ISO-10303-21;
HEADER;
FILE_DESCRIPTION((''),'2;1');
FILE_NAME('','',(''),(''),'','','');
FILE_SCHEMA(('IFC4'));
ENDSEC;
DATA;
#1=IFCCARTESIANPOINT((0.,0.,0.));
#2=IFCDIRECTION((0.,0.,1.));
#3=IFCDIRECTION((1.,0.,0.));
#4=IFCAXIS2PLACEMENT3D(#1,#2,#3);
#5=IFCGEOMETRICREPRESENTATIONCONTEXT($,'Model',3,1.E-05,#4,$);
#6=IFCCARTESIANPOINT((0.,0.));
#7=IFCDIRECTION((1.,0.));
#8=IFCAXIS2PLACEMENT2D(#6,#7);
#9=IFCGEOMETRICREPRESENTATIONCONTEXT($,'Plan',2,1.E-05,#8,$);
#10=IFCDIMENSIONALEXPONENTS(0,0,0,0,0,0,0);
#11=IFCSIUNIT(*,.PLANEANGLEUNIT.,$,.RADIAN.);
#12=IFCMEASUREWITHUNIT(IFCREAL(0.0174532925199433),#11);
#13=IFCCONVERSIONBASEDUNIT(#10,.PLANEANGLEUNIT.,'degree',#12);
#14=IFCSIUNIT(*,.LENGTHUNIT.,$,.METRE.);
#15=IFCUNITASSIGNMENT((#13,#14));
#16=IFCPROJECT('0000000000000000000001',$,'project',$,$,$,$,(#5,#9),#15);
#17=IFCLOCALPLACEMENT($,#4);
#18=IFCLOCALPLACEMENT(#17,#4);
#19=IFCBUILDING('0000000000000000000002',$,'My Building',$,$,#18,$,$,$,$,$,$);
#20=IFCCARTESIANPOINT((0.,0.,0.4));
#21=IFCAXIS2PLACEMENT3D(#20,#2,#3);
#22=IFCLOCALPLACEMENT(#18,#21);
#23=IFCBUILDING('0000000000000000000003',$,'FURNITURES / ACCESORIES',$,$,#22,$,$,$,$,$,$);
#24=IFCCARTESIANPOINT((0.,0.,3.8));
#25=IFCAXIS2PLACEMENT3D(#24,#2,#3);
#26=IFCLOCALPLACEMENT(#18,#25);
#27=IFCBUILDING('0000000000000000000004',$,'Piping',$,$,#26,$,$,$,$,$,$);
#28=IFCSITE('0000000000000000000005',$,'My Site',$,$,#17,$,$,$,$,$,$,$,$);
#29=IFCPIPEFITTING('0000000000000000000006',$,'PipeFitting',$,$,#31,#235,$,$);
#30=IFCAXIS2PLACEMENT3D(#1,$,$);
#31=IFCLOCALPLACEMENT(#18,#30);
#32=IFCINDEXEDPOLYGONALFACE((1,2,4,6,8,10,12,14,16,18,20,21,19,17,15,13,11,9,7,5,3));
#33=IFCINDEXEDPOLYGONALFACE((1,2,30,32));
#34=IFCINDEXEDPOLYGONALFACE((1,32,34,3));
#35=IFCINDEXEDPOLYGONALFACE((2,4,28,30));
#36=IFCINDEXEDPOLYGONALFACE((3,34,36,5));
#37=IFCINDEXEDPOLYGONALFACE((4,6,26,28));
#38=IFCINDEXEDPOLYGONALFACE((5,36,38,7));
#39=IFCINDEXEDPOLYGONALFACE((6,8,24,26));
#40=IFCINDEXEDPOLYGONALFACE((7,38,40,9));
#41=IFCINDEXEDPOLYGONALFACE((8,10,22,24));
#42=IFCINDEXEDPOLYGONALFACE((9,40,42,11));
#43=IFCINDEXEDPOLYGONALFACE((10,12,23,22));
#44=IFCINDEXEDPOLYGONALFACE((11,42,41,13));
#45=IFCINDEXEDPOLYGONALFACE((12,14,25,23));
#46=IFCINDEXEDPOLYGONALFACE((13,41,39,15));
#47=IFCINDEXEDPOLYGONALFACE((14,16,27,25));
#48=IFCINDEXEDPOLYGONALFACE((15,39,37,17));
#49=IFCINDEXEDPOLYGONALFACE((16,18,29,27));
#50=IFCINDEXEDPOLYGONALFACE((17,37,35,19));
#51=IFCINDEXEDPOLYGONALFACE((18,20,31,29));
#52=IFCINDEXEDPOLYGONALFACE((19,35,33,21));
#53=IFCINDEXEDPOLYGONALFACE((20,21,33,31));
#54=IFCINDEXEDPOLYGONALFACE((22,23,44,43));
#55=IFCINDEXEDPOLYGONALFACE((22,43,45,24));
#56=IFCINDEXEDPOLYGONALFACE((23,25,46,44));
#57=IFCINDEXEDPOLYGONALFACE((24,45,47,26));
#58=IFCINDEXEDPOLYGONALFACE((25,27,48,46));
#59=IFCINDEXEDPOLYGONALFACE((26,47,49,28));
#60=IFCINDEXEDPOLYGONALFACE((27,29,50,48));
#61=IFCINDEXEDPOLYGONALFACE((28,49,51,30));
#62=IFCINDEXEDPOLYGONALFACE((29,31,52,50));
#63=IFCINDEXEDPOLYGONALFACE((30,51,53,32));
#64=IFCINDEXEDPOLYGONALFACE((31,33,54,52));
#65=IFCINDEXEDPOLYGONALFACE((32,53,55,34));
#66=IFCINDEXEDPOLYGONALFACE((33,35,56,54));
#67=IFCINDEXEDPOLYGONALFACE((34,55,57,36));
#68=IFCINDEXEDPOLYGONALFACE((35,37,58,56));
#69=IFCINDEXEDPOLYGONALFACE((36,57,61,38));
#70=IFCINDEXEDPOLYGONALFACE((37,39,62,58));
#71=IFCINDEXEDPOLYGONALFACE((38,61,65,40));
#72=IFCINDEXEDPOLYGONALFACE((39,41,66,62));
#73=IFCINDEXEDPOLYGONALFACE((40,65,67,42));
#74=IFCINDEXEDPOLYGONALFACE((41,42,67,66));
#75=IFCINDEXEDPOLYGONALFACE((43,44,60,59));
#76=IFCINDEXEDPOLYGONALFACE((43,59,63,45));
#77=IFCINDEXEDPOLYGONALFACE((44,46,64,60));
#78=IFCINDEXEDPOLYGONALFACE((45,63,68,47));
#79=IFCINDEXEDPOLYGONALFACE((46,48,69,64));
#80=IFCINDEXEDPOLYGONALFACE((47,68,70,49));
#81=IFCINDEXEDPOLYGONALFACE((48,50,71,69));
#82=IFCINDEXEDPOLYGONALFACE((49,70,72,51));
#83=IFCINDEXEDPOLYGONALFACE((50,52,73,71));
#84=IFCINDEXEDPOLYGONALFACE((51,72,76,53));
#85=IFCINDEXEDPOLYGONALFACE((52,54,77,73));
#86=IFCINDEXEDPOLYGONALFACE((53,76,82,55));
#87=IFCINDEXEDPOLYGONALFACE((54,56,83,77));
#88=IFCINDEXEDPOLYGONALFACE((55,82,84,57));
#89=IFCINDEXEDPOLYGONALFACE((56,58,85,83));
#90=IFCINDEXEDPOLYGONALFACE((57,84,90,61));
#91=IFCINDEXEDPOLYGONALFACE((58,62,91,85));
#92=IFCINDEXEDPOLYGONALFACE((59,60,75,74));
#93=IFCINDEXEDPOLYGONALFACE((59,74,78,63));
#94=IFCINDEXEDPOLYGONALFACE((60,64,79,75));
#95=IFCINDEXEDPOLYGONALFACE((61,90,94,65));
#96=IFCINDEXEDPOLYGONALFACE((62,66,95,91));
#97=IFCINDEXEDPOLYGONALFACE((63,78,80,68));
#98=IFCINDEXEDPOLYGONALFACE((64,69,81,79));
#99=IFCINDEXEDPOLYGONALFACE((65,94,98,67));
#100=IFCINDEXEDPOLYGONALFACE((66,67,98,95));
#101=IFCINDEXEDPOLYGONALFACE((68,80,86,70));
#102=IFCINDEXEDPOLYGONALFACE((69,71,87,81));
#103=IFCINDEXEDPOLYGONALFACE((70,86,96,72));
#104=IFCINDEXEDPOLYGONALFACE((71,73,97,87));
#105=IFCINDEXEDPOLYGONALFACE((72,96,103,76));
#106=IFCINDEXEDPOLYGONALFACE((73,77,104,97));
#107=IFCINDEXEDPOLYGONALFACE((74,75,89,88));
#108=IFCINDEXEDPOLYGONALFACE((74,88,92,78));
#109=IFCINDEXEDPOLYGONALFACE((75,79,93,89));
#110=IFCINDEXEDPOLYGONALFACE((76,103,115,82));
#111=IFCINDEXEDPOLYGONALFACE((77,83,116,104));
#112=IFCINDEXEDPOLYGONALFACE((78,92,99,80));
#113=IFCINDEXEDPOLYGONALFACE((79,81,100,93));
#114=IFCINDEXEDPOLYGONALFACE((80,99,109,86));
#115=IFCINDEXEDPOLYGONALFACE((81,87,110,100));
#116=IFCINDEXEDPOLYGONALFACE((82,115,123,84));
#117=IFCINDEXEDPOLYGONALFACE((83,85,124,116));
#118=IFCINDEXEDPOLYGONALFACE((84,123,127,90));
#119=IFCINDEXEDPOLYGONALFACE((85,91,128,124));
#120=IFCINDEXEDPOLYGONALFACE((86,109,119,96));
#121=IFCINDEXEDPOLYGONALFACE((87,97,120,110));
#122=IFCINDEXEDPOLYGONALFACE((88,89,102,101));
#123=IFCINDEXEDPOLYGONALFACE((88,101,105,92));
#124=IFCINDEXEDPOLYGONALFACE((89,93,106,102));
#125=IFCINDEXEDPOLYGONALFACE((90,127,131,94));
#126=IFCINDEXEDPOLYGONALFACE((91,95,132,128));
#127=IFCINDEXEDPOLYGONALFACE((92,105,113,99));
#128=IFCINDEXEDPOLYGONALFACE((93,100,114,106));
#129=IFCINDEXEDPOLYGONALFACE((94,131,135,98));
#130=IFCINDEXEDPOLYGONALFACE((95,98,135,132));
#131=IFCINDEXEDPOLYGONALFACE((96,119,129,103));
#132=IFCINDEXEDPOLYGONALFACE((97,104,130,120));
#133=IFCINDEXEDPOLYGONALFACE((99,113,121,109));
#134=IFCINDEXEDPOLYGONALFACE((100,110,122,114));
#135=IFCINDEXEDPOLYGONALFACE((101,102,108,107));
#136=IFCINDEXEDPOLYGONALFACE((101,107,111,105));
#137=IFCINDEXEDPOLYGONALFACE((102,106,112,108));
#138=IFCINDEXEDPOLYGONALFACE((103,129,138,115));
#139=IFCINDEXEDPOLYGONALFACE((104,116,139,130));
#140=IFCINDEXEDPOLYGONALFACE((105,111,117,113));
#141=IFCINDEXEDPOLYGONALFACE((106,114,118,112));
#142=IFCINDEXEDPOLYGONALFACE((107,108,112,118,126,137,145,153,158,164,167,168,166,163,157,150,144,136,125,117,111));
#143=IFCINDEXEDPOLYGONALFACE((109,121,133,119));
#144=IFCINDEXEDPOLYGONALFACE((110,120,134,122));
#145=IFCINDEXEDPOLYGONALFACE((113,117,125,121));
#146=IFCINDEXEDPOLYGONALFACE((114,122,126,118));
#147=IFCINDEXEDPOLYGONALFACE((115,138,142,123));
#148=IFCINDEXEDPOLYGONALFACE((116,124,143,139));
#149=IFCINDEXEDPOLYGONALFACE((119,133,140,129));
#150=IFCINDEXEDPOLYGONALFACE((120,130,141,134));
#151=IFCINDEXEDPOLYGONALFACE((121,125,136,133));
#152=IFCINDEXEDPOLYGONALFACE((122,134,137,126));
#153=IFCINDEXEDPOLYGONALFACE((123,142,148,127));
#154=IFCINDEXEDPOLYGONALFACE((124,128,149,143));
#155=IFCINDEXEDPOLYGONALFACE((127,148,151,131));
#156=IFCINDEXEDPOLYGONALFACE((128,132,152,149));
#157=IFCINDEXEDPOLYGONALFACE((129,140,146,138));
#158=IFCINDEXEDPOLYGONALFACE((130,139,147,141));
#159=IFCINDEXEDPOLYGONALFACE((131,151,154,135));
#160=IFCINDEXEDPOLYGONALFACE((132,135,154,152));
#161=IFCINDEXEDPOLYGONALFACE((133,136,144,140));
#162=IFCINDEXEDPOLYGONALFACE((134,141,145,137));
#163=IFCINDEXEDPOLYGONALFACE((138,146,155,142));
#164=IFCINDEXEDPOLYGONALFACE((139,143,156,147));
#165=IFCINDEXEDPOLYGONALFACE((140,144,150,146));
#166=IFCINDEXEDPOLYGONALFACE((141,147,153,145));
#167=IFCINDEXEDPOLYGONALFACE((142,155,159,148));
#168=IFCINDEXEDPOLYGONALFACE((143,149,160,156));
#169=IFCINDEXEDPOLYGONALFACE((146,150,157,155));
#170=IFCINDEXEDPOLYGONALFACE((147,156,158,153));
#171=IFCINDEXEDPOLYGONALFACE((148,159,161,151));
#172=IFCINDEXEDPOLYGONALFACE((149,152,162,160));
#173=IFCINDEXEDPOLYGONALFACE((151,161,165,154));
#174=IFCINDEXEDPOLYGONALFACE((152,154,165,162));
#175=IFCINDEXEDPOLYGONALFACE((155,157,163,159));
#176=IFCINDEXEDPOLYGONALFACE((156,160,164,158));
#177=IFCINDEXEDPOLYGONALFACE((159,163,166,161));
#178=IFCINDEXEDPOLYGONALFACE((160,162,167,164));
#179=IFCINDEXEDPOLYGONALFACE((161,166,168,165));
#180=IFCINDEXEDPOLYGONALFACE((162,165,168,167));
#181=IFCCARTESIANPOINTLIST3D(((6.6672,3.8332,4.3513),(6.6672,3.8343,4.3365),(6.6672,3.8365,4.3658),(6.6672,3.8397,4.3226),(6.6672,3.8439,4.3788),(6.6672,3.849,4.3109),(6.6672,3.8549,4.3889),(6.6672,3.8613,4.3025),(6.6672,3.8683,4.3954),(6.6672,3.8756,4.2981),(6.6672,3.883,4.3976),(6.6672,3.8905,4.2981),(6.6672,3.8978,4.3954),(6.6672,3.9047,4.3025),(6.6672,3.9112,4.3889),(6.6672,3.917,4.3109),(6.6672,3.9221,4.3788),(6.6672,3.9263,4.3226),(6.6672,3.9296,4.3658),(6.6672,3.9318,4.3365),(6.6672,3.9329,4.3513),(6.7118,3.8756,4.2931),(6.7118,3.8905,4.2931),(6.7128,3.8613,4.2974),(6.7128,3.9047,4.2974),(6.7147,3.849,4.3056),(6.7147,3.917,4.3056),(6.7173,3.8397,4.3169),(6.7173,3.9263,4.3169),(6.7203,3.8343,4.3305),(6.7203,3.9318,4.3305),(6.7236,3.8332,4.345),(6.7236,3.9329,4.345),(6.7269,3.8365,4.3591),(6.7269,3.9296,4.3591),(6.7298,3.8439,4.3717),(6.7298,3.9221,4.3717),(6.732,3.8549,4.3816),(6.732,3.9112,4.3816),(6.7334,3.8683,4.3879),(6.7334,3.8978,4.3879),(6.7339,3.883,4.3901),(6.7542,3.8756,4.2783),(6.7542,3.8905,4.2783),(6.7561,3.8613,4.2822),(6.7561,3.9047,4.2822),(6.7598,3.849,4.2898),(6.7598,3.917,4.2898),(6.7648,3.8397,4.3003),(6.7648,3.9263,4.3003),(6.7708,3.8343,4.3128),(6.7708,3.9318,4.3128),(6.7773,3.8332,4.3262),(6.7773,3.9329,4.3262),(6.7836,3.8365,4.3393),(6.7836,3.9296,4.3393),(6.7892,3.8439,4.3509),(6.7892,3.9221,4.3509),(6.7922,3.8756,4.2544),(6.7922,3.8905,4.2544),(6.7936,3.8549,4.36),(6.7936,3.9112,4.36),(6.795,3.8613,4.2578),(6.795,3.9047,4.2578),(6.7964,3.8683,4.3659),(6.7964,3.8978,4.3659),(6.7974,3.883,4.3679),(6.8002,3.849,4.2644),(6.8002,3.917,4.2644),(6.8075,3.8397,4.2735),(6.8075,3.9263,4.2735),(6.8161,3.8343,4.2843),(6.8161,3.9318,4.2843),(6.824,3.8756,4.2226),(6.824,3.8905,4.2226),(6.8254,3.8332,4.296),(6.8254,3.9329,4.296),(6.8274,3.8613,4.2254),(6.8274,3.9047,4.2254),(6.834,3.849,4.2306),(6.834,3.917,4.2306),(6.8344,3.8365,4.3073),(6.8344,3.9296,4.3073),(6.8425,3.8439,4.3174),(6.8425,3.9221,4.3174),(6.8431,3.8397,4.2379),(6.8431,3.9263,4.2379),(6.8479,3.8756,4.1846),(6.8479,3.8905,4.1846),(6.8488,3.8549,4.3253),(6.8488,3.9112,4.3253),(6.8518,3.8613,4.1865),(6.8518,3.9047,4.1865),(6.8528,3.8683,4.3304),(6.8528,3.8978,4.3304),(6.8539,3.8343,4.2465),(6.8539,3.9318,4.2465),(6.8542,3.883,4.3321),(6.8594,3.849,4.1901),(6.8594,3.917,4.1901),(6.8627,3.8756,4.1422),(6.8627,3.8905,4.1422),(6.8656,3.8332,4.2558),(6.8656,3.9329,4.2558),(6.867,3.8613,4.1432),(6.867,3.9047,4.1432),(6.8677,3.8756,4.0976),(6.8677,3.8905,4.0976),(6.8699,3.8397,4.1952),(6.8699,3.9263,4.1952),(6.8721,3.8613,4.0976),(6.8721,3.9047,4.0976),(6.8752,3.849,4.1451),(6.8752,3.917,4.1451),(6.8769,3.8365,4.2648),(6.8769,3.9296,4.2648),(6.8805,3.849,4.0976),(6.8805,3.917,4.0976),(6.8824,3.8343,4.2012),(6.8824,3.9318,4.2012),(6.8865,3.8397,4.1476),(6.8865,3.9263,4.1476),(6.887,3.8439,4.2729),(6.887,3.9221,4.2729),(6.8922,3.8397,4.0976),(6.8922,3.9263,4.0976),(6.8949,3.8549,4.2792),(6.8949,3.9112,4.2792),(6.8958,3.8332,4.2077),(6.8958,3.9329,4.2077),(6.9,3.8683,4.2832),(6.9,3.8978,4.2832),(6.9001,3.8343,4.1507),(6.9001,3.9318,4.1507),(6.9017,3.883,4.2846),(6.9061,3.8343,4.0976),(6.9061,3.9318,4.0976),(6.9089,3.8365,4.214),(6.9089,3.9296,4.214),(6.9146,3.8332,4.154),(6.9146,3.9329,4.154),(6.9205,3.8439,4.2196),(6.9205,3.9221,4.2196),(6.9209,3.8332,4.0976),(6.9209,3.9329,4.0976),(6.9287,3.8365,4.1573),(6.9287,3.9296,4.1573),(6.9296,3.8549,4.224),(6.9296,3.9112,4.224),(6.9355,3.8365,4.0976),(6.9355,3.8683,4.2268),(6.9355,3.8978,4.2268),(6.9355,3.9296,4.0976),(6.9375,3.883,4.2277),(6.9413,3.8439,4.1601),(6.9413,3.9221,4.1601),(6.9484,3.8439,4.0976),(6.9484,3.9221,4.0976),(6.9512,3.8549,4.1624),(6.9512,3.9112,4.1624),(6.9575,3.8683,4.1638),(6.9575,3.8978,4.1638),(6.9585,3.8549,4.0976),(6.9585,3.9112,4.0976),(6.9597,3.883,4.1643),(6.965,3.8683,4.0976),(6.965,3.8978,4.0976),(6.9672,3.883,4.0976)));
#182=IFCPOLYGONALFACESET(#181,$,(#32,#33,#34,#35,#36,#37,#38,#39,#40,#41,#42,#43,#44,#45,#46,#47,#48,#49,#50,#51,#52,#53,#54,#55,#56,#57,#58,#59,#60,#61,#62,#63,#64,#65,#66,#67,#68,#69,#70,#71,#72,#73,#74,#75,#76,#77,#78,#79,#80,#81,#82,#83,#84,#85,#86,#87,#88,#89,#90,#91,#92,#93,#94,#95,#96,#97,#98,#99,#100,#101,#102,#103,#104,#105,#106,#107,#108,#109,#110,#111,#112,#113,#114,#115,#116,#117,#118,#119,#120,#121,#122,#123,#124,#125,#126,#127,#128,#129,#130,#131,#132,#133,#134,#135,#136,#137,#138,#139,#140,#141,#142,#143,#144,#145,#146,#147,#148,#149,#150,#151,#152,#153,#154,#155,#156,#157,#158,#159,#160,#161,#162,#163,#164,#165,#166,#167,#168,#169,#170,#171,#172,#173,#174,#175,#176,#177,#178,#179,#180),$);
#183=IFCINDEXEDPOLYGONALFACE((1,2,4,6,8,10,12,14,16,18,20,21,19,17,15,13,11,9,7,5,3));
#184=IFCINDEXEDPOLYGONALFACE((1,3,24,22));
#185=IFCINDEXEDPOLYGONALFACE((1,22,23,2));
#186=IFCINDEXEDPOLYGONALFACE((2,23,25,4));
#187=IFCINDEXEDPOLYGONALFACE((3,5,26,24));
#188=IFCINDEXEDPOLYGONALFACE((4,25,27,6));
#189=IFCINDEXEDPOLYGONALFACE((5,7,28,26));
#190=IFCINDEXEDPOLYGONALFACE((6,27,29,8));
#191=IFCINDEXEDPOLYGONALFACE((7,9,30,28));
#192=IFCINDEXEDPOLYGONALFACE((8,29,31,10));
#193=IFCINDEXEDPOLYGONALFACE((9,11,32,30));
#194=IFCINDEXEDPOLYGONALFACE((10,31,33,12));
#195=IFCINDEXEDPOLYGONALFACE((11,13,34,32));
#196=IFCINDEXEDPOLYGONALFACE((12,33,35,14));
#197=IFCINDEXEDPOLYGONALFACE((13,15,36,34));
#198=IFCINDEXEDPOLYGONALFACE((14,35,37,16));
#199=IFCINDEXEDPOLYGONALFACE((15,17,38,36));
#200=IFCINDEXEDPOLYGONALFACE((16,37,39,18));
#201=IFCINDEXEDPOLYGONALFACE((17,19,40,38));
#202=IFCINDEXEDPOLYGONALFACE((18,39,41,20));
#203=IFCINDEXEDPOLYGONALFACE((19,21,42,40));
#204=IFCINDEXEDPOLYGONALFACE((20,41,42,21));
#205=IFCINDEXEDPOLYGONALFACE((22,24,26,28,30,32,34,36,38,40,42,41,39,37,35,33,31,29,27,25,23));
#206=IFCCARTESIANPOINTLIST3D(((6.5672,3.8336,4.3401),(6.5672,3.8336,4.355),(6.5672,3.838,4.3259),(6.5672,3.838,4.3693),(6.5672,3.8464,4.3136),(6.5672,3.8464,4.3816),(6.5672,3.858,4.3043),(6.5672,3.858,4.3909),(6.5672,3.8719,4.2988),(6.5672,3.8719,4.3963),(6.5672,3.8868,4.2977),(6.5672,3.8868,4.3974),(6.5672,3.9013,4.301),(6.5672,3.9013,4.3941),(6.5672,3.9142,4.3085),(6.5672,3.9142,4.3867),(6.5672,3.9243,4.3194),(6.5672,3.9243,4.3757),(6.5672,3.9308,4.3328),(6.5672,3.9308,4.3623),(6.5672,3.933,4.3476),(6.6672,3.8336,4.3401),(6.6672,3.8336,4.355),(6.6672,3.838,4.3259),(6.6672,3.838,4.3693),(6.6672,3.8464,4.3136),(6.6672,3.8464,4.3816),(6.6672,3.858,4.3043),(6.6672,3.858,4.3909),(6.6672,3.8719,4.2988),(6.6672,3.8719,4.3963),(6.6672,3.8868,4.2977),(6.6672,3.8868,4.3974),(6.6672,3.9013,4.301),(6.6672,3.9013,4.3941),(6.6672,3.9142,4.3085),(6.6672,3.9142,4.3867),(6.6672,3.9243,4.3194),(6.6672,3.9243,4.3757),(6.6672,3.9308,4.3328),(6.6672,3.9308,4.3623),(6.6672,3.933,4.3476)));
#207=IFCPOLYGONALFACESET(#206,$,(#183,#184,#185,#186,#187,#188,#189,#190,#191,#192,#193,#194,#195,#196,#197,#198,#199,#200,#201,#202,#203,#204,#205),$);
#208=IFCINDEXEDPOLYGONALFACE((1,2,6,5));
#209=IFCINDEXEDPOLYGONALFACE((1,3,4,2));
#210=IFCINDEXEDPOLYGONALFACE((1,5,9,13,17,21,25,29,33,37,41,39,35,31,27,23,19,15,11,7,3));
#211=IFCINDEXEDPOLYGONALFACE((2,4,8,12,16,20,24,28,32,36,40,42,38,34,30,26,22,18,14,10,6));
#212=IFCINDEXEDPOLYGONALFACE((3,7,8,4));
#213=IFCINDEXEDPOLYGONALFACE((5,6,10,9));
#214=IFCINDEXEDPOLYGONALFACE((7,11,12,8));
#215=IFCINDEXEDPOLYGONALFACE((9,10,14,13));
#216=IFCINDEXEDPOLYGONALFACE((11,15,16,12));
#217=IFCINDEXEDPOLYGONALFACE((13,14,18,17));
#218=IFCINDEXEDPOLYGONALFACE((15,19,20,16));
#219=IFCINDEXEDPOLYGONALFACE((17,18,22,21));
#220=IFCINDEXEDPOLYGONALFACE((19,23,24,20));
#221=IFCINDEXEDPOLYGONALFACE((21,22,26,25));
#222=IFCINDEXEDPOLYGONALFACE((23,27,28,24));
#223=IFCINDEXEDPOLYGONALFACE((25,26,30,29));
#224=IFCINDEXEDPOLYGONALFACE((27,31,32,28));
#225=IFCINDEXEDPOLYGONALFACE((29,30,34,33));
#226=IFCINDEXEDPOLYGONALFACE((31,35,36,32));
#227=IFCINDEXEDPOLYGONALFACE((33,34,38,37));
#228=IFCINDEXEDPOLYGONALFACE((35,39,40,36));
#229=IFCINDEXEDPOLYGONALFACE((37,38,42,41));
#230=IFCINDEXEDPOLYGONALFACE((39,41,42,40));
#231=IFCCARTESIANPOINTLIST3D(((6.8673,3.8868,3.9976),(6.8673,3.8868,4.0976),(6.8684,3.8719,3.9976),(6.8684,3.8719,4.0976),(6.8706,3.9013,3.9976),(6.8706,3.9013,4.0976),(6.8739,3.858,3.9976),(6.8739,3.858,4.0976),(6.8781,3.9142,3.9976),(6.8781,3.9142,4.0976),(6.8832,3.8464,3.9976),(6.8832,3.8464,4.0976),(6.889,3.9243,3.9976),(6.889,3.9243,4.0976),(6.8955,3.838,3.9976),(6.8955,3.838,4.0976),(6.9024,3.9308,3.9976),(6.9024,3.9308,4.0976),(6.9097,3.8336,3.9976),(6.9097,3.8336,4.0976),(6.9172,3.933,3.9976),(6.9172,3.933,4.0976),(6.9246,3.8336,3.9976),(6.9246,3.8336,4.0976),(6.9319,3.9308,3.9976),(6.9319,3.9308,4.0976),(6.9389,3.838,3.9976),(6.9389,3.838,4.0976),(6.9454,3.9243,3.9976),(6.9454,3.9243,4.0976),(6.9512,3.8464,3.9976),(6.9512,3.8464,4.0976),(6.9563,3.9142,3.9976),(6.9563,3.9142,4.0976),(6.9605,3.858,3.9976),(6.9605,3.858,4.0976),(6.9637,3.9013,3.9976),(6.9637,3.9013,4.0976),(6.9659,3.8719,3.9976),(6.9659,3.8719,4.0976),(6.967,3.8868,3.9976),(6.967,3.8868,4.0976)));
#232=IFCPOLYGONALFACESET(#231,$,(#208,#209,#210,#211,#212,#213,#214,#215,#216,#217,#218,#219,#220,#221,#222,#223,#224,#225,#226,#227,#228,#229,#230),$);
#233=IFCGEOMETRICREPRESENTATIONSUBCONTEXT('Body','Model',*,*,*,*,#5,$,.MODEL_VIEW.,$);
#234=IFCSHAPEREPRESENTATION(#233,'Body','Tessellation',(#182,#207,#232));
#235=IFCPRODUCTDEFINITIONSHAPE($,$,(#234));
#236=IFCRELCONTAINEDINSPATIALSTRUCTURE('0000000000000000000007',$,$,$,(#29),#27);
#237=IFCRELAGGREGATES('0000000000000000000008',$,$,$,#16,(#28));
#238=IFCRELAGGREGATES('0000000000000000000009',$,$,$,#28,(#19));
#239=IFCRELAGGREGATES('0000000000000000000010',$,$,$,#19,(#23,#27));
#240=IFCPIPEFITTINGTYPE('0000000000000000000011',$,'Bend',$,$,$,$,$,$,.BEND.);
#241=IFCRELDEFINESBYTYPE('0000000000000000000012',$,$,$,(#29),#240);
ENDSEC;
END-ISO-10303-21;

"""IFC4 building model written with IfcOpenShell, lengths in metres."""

from ifc_helpers import new_model, entity, si_unit, converted_unit, frame, origin_with_axes, origin_2d_with_axis, place, context, subcontext, project, spatial, circle, extrude, source, transform, mapped, type_object, type_shapes, element, save


model = new_model("IFC4")

# Units and contexts
model_context = context("Model", 3, precision=1e-05, world=origin_with_axes())
plan_context = context("Plan", 2, precision=1e-05, world=origin_2d_with_axis())
body_context = subcontext(model_context, "Body", "Model", "MODEL_VIEW")
ifc_project = project(units=[converted_unit("PLANEANGLEUNIT", "degree", entity("IfcReal", 0.0174532925199433), si_unit("PLANEANGLEUNIT", "RADIAN"), dimensions=[0, 0, 0, 0, 0, 0, 0]), si_unit("LENGTHUNIT", "METRE")], contexts=[model_context, plan_context])

# Site, building
site_placement = place(None, origin_with_axes())
site = spatial("IfcSite", under=ifc_project, at=site_placement, Name="My Site")
building_1_placement = place(site_placement, origin_with_axes())
building_1 = spatial("IfcBuilding", under=site, at=building_1_placement, Name="My Building")

# Shared definitions
building_2_placement = place(building_1_placement, frame((0.0, 0.0, 0.4), z_axis=(0.0, 0.0, 1.0), x_axis=(1.0, 0.0, 0.0)))
building_2 = spatial("IfcBuilding", under=building_1, at=building_2_placement, Name="FURNITURES / ACCESORIES")

# Shared definitions
building_3_placement = place(building_1_placement, frame((0.0, 0.0, 3.8), z_axis=(0.0, 0.0, 1.0), x_axis=(1.0, 0.0, 0.0)))
building_3 = spatial("IfcBuilding", under=building_1, at=building_3_placement, Name="Piping")

# Pipe fitting
pipe_fitting_type = type_object("IfcPipeFittingType", Name="Bend", PredefinedType="BEND")
shared_shape = source(origin_with_axes(), body_context, "Body", "SolidModel", [
    entity("IfcSweptDiskSolid", entity("IfcIndexedPolyCurve", entity("IfcCartesianPointList3D", [[0.0, 0.0, 0.1], [0.0, -0.0732, 0.2768], [0.0, -0.25, 0.35]]), [entity("IfcArcIndex", [1, 2, 3])]), 0.05),
    extrude(circle(Radius=0.05), origin_with_axes(), (0.0, 0.0, 1.0), 0.1),
    extrude(circle(Radius=0.05), frame((0.0, -0.25, 0.35), z_axis=(0.0, -1.0, -0.000001), x_axis=(1.0, 0.0, 0.0)), (0.0, 0.0, 1.0), 0.1),
])
type_shapes(pipe_fitting_type, [shared_shape])
for number, where, z_axis, x_axis, name in (
    (1, (6.5672, 3.883, 0.5476), (1.0, -0.000001, 0.000001), (0.000001, 1.0, 0.0), "PipeFitting"),
):
    element("IfcPipeFitting", number, at=place(building_3_placement, frame(where, z_axis=z_axis, x_axis=x_axis)), inside=building_3, type_object=pipe_fitting_type, Name=name, context=body_context, shape_type="MappedRepresentation", body=[
        mapped(shared_shape, transform((0.0, 0.0, 0.0), x_axis=(1.0, 0.0, 0.0), y_axis=(0.0, 1.0, 0.0), z_axis=(0.0, 0.0, 1.0), scale=1.0)),
    ])

save(model, "model.ifc")
